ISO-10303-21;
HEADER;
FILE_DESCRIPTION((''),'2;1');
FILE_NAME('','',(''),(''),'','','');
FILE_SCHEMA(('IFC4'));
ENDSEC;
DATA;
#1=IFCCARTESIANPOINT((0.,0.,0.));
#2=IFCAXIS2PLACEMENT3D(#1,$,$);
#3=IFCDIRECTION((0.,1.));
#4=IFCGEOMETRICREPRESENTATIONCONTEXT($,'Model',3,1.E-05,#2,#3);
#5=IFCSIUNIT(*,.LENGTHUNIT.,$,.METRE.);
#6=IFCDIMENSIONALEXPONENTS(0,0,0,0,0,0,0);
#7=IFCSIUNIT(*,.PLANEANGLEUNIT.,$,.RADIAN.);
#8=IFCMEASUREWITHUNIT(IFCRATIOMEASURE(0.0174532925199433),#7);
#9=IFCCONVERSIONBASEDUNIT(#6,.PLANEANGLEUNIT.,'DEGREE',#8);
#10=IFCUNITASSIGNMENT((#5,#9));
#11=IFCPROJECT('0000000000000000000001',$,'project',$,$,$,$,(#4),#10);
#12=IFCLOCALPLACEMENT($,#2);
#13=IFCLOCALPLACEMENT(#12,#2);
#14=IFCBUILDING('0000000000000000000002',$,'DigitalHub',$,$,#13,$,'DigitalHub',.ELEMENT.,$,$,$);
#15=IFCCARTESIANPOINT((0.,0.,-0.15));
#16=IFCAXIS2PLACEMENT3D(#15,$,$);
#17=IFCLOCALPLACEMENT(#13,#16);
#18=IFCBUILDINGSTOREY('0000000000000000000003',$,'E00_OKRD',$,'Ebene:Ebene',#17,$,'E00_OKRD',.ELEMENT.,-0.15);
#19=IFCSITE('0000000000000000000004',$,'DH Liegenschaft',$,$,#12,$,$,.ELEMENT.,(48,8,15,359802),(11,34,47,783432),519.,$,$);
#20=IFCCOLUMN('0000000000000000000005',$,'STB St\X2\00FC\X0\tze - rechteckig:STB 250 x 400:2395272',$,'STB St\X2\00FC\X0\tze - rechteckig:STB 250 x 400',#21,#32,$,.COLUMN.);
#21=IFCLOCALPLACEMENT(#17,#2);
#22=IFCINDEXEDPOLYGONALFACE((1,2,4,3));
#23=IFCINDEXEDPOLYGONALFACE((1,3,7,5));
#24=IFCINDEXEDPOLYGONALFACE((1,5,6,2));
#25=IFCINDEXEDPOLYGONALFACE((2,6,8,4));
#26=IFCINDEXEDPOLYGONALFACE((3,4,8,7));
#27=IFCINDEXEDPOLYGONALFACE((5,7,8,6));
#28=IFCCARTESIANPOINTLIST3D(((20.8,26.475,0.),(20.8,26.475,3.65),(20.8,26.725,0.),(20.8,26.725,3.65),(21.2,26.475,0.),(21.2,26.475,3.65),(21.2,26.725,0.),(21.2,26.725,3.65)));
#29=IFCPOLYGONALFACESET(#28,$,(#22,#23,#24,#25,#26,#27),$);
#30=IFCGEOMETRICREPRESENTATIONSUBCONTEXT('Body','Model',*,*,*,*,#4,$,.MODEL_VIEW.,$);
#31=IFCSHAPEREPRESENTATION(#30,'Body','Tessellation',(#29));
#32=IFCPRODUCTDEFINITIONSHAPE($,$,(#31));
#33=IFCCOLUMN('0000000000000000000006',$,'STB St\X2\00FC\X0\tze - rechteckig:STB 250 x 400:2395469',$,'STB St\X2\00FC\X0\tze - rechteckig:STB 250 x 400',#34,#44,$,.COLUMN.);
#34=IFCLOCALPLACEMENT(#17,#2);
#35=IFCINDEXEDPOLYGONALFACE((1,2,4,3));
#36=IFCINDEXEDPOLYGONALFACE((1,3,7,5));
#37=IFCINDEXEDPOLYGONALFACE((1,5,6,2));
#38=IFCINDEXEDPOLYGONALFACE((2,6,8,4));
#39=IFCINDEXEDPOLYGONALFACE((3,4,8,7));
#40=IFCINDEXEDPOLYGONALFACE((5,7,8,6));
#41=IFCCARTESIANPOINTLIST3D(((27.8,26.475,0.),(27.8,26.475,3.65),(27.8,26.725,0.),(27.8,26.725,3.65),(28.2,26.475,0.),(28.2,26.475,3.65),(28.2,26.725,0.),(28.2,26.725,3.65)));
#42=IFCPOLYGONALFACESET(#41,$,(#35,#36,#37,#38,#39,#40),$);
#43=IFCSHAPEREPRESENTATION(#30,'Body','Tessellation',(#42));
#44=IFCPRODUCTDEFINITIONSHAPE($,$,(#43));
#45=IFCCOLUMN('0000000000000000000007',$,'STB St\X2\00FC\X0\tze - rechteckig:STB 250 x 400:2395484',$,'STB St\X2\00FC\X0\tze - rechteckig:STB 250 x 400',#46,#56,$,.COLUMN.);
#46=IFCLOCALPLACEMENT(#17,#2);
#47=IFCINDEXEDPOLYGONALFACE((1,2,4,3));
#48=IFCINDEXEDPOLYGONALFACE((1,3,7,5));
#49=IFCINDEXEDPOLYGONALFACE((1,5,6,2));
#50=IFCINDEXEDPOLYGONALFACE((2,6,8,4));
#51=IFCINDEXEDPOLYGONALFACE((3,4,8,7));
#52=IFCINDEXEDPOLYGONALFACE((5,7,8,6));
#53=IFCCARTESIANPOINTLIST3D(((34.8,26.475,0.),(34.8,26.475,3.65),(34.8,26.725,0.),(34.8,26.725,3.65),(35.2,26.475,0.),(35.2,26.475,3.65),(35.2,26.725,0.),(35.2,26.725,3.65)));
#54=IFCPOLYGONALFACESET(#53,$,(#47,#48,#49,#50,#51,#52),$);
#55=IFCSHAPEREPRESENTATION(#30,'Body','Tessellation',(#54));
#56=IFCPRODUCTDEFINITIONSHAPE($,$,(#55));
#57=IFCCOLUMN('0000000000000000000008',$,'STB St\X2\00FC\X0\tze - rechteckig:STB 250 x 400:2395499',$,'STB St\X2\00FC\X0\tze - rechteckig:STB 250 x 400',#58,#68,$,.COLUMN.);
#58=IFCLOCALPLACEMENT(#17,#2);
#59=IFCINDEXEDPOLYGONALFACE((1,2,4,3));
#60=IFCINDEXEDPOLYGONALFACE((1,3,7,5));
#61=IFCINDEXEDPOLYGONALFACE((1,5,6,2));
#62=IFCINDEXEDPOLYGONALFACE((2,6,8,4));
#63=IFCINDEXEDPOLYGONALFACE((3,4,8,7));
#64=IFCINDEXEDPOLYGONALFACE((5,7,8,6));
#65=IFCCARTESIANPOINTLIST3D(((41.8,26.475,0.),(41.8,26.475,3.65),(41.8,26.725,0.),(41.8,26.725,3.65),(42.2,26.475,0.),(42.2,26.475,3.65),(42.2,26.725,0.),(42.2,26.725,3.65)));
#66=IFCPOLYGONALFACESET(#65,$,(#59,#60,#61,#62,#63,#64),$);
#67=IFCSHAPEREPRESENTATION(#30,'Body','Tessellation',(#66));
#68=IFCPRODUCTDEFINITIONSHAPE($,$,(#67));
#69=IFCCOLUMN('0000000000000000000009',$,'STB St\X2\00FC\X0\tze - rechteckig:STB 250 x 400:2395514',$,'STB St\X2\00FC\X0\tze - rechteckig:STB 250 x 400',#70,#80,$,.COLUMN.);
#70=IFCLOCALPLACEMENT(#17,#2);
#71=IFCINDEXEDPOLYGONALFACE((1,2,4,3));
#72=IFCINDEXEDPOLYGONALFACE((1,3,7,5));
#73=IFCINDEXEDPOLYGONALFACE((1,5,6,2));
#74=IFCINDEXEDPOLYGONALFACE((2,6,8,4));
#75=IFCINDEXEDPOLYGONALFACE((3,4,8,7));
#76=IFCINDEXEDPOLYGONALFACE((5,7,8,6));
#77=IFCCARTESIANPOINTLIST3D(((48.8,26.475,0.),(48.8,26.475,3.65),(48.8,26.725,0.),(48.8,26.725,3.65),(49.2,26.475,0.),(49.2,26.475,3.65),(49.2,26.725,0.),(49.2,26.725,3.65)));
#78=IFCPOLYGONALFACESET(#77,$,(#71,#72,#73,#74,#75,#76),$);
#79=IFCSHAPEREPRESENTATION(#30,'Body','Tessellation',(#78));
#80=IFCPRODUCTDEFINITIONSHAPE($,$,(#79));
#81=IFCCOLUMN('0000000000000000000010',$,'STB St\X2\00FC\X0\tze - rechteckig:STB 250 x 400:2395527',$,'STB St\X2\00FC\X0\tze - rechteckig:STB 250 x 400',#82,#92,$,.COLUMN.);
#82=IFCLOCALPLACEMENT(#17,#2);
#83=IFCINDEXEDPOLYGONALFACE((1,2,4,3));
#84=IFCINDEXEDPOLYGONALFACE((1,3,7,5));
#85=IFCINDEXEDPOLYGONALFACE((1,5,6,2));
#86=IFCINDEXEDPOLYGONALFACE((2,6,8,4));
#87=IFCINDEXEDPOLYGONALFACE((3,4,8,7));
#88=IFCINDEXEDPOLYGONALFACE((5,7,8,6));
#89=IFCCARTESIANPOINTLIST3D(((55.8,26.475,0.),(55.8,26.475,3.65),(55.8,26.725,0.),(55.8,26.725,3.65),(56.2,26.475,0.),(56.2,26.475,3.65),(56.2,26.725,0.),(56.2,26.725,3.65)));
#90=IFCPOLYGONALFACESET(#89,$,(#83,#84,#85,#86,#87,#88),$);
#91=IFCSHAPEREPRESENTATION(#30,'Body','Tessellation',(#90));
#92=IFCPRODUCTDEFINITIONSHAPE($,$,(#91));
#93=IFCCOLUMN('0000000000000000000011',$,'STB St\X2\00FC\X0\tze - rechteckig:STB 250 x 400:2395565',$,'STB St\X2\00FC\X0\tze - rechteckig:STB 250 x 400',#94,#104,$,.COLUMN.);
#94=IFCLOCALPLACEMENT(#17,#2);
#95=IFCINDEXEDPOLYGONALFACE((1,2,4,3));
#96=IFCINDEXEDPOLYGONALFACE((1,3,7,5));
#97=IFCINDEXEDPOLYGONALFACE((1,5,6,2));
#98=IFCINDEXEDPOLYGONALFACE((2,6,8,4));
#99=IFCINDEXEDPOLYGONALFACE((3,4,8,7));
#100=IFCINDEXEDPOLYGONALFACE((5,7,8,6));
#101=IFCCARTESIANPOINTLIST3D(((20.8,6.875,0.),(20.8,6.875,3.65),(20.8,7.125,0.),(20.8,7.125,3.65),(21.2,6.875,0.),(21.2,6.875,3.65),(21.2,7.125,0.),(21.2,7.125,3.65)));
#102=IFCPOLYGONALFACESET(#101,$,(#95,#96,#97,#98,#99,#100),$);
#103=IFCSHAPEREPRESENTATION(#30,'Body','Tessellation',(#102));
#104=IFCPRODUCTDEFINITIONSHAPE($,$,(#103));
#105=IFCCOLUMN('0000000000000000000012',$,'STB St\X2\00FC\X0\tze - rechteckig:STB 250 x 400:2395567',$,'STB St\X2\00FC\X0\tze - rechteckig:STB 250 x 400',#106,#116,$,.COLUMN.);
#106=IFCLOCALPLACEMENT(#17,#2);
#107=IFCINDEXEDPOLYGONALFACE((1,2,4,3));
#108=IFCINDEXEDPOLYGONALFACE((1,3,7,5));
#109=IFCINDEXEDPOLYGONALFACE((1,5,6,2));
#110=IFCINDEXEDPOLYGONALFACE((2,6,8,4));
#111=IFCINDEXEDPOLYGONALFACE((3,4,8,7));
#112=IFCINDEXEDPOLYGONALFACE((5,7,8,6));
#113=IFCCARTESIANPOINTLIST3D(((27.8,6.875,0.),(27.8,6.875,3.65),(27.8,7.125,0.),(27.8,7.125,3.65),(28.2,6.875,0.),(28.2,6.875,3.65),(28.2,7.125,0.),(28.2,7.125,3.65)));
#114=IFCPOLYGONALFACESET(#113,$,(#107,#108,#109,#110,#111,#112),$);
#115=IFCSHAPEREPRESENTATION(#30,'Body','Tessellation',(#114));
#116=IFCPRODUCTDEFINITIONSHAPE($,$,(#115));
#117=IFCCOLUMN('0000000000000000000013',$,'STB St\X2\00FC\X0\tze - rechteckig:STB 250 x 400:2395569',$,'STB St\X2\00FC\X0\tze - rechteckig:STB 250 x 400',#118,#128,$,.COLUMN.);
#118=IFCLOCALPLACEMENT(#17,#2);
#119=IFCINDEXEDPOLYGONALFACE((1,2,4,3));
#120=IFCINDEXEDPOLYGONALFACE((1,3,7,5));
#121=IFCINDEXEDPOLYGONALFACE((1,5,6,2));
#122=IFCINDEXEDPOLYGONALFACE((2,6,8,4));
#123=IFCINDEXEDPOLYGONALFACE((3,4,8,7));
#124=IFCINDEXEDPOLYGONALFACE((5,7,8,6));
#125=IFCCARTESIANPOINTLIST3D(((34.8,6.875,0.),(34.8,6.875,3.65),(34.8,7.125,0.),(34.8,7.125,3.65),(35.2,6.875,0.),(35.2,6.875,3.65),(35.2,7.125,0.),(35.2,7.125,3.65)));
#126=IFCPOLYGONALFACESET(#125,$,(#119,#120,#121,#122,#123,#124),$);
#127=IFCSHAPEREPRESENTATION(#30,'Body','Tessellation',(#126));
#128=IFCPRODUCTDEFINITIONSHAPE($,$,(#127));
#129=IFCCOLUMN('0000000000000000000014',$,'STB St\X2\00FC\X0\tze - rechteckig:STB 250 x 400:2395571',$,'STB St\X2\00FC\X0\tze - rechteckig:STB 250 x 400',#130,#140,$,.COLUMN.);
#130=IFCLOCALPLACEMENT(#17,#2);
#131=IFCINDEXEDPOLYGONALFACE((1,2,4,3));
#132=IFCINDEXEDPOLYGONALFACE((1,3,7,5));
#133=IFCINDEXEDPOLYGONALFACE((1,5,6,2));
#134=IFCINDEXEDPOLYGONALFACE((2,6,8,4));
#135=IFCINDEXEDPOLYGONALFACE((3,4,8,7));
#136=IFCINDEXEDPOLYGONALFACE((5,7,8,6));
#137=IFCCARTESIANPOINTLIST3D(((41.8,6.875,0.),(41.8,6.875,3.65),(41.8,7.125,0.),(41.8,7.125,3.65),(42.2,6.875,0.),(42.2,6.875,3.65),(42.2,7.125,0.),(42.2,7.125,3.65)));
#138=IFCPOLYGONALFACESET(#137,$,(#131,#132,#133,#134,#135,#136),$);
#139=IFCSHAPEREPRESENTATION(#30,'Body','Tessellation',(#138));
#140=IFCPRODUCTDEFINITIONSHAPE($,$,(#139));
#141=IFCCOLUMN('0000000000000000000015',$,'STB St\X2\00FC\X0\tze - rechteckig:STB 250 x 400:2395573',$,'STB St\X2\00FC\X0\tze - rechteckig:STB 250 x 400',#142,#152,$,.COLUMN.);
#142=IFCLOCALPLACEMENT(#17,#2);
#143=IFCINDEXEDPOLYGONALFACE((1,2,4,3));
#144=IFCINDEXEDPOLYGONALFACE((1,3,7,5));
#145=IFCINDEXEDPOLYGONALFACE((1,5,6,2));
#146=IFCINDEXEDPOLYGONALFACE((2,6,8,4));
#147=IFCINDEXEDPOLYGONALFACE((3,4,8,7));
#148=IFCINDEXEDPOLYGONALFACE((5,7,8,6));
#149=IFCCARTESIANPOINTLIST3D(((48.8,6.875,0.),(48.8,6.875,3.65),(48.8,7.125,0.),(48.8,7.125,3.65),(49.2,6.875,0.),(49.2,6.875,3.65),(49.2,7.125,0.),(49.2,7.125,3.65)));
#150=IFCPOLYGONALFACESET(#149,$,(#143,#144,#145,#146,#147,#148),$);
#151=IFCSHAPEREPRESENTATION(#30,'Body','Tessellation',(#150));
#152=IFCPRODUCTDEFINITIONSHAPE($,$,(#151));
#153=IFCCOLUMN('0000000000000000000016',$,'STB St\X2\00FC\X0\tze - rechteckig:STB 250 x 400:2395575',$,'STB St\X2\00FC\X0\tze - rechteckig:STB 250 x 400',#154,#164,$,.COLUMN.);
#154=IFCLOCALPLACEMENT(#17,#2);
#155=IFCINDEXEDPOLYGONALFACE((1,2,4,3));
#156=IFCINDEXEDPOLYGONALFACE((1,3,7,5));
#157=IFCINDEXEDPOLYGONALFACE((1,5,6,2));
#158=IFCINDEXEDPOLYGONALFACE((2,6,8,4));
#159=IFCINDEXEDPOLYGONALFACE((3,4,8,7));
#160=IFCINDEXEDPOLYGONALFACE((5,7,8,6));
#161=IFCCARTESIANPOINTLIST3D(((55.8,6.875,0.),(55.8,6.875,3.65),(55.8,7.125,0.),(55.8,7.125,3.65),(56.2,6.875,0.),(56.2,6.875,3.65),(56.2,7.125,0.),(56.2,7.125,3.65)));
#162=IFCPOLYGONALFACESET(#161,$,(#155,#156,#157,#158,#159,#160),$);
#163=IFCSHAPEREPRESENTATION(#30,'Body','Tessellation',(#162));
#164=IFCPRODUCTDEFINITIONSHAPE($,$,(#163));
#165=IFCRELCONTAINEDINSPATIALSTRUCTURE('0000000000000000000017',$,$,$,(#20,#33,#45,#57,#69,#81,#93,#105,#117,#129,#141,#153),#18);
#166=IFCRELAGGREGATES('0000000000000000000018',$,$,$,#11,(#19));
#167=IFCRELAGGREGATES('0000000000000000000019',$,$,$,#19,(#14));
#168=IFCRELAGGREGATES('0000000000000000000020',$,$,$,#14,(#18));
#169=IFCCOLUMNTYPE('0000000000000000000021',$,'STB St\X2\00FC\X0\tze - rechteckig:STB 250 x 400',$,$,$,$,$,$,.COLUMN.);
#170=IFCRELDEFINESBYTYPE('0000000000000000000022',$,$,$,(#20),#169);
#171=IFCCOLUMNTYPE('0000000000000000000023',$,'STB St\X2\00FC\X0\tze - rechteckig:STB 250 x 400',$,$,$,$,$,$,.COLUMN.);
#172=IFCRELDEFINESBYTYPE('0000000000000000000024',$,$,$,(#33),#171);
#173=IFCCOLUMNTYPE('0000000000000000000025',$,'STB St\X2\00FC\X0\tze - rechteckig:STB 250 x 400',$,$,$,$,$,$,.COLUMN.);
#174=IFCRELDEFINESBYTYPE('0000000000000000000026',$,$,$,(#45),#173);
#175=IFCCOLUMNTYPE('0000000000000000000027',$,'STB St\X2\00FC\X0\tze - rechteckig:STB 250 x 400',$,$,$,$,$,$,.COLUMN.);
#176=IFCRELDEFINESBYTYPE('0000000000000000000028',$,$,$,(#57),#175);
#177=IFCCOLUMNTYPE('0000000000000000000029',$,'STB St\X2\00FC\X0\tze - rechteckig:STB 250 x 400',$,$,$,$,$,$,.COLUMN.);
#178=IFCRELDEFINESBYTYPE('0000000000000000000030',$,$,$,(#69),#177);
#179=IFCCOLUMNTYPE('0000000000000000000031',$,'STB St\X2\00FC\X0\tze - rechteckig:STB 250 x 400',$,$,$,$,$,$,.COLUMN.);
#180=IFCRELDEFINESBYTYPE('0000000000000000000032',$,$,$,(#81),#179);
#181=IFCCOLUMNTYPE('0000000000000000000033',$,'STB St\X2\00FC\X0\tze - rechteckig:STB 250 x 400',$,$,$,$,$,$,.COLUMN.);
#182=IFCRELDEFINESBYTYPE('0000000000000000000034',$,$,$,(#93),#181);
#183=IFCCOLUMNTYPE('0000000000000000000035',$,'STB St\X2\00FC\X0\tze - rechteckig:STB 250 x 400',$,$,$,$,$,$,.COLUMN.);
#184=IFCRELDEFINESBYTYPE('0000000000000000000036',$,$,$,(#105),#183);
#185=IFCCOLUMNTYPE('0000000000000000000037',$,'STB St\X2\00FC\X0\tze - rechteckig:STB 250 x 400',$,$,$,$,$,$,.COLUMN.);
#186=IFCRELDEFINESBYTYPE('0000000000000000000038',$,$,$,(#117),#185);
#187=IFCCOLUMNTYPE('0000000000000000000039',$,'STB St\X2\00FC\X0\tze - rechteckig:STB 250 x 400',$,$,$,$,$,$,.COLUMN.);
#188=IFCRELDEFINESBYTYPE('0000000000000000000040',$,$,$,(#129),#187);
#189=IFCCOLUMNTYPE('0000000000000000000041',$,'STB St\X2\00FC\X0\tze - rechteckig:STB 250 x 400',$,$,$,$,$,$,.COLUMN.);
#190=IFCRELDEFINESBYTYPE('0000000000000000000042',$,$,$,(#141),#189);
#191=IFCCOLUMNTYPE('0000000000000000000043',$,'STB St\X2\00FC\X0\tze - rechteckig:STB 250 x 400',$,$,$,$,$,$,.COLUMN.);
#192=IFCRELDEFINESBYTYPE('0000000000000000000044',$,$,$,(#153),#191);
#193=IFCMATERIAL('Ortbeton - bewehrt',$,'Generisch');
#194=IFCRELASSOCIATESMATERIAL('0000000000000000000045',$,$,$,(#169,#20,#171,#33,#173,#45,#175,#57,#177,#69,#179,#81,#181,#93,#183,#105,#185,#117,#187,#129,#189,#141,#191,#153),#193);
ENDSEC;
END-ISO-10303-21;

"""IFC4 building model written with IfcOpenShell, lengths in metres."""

from ifc_helpers import new_model, entity, si_unit, converted_unit, direction, frame, origin, place, context, subcontext, project, spatial, indexed_curve, outline, extrude, source, transform, mapped, material, type_object, type_shapes, element, save


model = new_model("IFC4")

# Units and contexts
model_context = context("Model", 3, precision=1e-05, world=origin(), true_north=direction((0.0, 1.0)))
body_context = subcontext(model_context, "Body", "Model", "MODEL_VIEW")
ifc_project = project(units=[si_unit("LENGTHUNIT", "METRE"), converted_unit("PLANEANGLEUNIT", "DEGREE", entity("IfcRatioMeasure", 0.0174532925199433), si_unit("PLANEANGLEUNIT", "RADIAN"), dimensions=[0, 0, 0, 0, 0, 0, 0])], contexts=[model_context])

# Site, building, storey
site_placement = place(None, frame((0.0, 0.0, 0.0)))
site = spatial("IfcSite", under=ifc_project, at=site_placement, Name="DH Liegenschaft", CompositionType="ELEMENT", RefLatitude=(48, 8, 15, 359802), RefLongitude=(11, 34, 47, 783432), RefElevation=519.0)
building_placement = place(site_placement, origin())
building = spatial("IfcBuilding", under=site, at=building_placement, Name="DigitalHub", LongName="DigitalHub", CompositionType="ELEMENT")
storey_placement = place(building_placement, frame((0.0, 0.0, -0.15)))
storey = spatial("IfcBuildingStorey", under=building, at=storey_placement, Name="E00_OKRD", ObjectType="Ebene:Ebene", LongName="E00_OKRD", CompositionType="ELEMENT", Elevation=-0.15)

# Columns
ifc_material_1 = material(Name="Ortbeton - bewehrt", Category="Generisch")
column_type_1 = type_object("IfcColumnType", Name="STB Stütze - rechteckig:STB 250 x 400", PredefinedType="COLUMN", material=ifc_material_1)
shared_shape_1 = source(origin(), body_context, "Body", "SweptSolid", [
    extrude(outline(indexed_curve([(-0.125, -0.2), (0.125, -0.2), (0.125, 0.2), (-0.125, 0.2), (-0.125, -0.2)], self_intersect=False)), frame((21.0, 26.6, -0.15), z_axis=(0.0, 0.0, 1.0), x_axis=(0.0, -1.0, 0.0)), (0.0, 0.0, 1.0), 3.65),
])
type_shapes(column_type_1, [shared_shape_1])
column_1_placement = place(storey_placement, frame((0.0, 0.0, 0.15)))
element("IfcColumn", 1, at=column_1_placement, inside=storey, type_object=column_type_1, material=ifc_material_1, Name="STB Stütze - rechteckig:STB 250 x 400:2395272", ObjectType="STB Stütze - rechteckig:STB 250 x 400", PredefinedType="COLUMN", context=body_context, shape_type="MappedRepresentation", body=[
    mapped(shared_shape_1, transform((0.0, 0.0, 0.0), scale=1.0)),
])
column_type_2 = type_object("IfcColumnType", Name="STB Stütze - rechteckig:STB 250 x 400", PredefinedType="COLUMN", material=ifc_material_1)
shared_shape_2 = source(origin(), body_context, "Body", "SweptSolid", [
    extrude(outline(indexed_curve([(-0.125, -0.2), (0.125, -0.2), (0.125, 0.2), (-0.125, 0.2), (-0.125, -0.2)], self_intersect=False)), frame((28.0, 26.6, -0.15), z_axis=(0.0, 0.0, 1.0), x_axis=(0.0, -1.0, 0.0)), (0.0, 0.0, 1.0), 3.65),
])
type_shapes(column_type_2, [shared_shape_2])
column_2_placement = place(storey_placement, frame((0.0, 0.0, 0.15)))
element("IfcColumn", 2, at=column_2_placement, inside=storey, type_object=column_type_2, material=ifc_material_1, Name="STB Stütze - rechteckig:STB 250 x 400:2395469", ObjectType="STB Stütze - rechteckig:STB 250 x 400", PredefinedType="COLUMN", context=body_context, shape_type="MappedRepresentation", body=[
    mapped(shared_shape_2, transform((0.0, 0.0, 0.0), scale=1.0)),
])
column_type_3 = type_object("IfcColumnType", Name="STB Stütze - rechteckig:STB 250 x 400", PredefinedType="COLUMN", material=ifc_material_1)
shared_shape_3 = source(origin(), body_context, "Body", "SweptSolid", [
    extrude(outline(indexed_curve([(-0.125, -0.2), (0.125, -0.2), (0.125, 0.2), (-0.125, 0.2), (-0.125, -0.2)], self_intersect=False)), frame((35.0, 26.6, -0.15), z_axis=(0.0, 0.0, 1.0), x_axis=(0.0, -1.0, 0.0)), (0.0, 0.0, 1.0), 3.65),
])
type_shapes(column_type_3, [shared_shape_3])
column_3_placement = place(storey_placement, frame((0.0, 0.0, 0.15)))
element("IfcColumn", 3, at=column_3_placement, inside=storey, type_object=column_type_3, material=ifc_material_1, Name="STB Stütze - rechteckig:STB 250 x 400:2395484", ObjectType="STB Stütze - rechteckig:STB 250 x 400", PredefinedType="COLUMN", context=body_context, shape_type="MappedRepresentation", body=[
    mapped(shared_shape_3, transform((0.0, 0.0, 0.0), scale=1.0)),
])
column_type_4 = type_object("IfcColumnType", Name="STB Stütze - rechteckig:STB 250 x 400", PredefinedType="COLUMN", material=ifc_material_1)
shared_shape_4 = source(origin(), body_context, "Body", "SweptSolid", [
    extrude(outline(indexed_curve([(-0.125, -0.2), (0.125, -0.2), (0.125, 0.2), (-0.125, 0.2), (-0.125, -0.2)], self_intersect=False)), frame((42.0, 26.6, -0.15), z_axis=(0.0, 0.0, 1.0), x_axis=(0.0, -1.0, 0.0)), (0.0, 0.0, 1.0), 3.65),
])
type_shapes(column_type_4, [shared_shape_4])
column_4_placement = place(storey_placement, frame((0.0, 0.0, 0.15)))
element("IfcColumn", 4, at=column_4_placement, inside=storey, type_object=column_type_4, material=ifc_material_1, Name="STB Stütze - rechteckig:STB 250 x 400:2395499", ObjectType="STB Stütze - rechteckig:STB 250 x 400", PredefinedType="COLUMN", context=body_context, shape_type="MappedRepresentation", body=[
    mapped(shared_shape_4, transform((0.0, 0.0, 0.0), scale=1.0)),
])
column_type_5 = type_object("IfcColumnType", Name="STB Stütze - rechteckig:STB 250 x 400", PredefinedType="COLUMN", material=ifc_material_1)
shared_shape_5 = source(origin(), body_context, "Body", "SweptSolid", [
    extrude(outline(indexed_curve([(-0.125, -0.2), (0.125, -0.2), (0.125, 0.2), (-0.125, 0.2), (-0.125, -0.2)], self_intersect=False)), frame((49.0, 26.6, -0.15), z_axis=(0.0, 0.0, 1.0), x_axis=(0.0, -1.0, 0.0)), (0.0, 0.0, 1.0), 3.65),
])
type_shapes(column_type_5, [shared_shape_5])
column_5_placement = place(storey_placement, frame((0.0, 0.0, 0.15)))
element("IfcColumn", 5, at=column_5_placement, inside=storey, type_object=column_type_5, material=ifc_material_1, Name="STB Stütze - rechteckig:STB 250 x 400:2395514", ObjectType="STB Stütze - rechteckig:STB 250 x 400", PredefinedType="COLUMN", context=body_context, shape_type="MappedRepresentation", body=[
    mapped(shared_shape_5, transform((0.0, 0.0, 0.0), scale=1.0)),
])
column_type_6 = type_object("IfcColumnType", Name="STB Stütze - rechteckig:STB 250 x 400", PredefinedType="COLUMN", material=ifc_material_1)
shared_shape_6 = source(origin(), body_context, "Body", "SweptSolid", [
    extrude(outline(indexed_curve([(-0.125, -0.2), (0.125, -0.2), (0.125, 0.2), (-0.125, 0.2), (-0.125, -0.2)], self_intersect=False)), frame((56.0, 26.6, -0.15), z_axis=(0.0, 0.0, 1.0), x_axis=(0.0, -1.0, 0.0)), (0.0, 0.0, 1.0), 3.65),
])
type_shapes(column_type_6, [shared_shape_6])
column_6_placement = place(storey_placement, frame((0.0, 0.0, 0.15)))
element("IfcColumn", 6, at=column_6_placement, inside=storey, type_object=column_type_6, material=ifc_material_1, Name="STB Stütze - rechteckig:STB 250 x 400:2395527", ObjectType="STB Stütze - rechteckig:STB 250 x 400", PredefinedType="COLUMN", context=body_context, shape_type="MappedRepresentation", body=[
    mapped(shared_shape_6, transform((0.0, 0.0, 0.0), scale=1.0)),
])
column_type_7 = type_object("IfcColumnType", Name="STB Stütze - rechteckig:STB 250 x 400", PredefinedType="COLUMN", material=ifc_material_1)
shared_shape_7 = source(origin(), body_context, "Body", "SweptSolid", [
    extrude(outline(indexed_curve([(-0.125, -0.2), (0.125, -0.2), (0.125, 0.2), (-0.125, 0.2), (-0.125, -0.2)], self_intersect=False)), frame((21.0, 7.0, -0.15), z_axis=(0.0, 0.0, 1.0), x_axis=(0.0, -1.0, 0.0)), (0.0, 0.0, 1.0), 3.65),
])
type_shapes(column_type_7, [shared_shape_7])
column_7_placement = place(storey_placement, frame((0.0, 0.0, 0.15)))
element("IfcColumn", 7, at=column_7_placement, inside=storey, type_object=column_type_7, material=ifc_material_1, Name="STB Stütze - rechteckig:STB 250 x 400:2395565", ObjectType="STB Stütze - rechteckig:STB 250 x 400", PredefinedType="COLUMN", context=body_context, shape_type="MappedRepresentation", body=[
    mapped(shared_shape_7, transform((0.0, 0.0, 0.0), scale=1.0)),
])
column_type_8 = type_object("IfcColumnType", Name="STB Stütze - rechteckig:STB 250 x 400", PredefinedType="COLUMN", material=ifc_material_1)
shared_shape_8 = source(origin(), body_context, "Body", "SweptSolid", [
    extrude(outline(indexed_curve([(-0.125, -0.2), (0.125, -0.2), (0.125, 0.2), (-0.125, 0.2), (-0.125, -0.2)], self_intersect=False)), frame((28.0, 7.0, -0.15), z_axis=(0.0, 0.0, 1.0), x_axis=(0.0, -1.0, 0.0)), (0.0, 0.0, 1.0), 3.65),
])
type_shapes(column_type_8, [shared_shape_8])
column_8_placement = place(storey_placement, frame((0.0, 0.0, 0.15)))
element("IfcColumn", 8, at=column_8_placement, inside=storey, type_object=column_type_8, material=ifc_material_1, Name="STB Stütze - rechteckig:STB 250 x 400:2395567", ObjectType="STB Stütze - rechteckig:STB 250 x 400", PredefinedType="COLUMN", context=body_context, shape_type="MappedRepresentation", body=[
    mapped(shared_shape_8, transform((0.0, 0.0, 0.0), scale=1.0)),
])
column_type_9 = type_object("IfcColumnType", Name="STB Stütze - rechteckig:STB 250 x 400", PredefinedType="COLUMN", material=ifc_material_1)
shared_shape_9 = source(origin(), body_context, "Body", "SweptSolid", [
    extrude(outline(indexed_curve([(-0.125, -0.2), (0.125, -0.2), (0.125, 0.2), (-0.125, 0.2), (-0.125, -0.2)], self_intersect=False)), frame((35.0, 7.0, -0.15), z_axis=(0.0, 0.0, 1.0), x_axis=(0.0, -1.0, 0.0)), (0.0, 0.0, 1.0), 3.65),
])
type_shapes(column_type_9, [shared_shape_9])
column_9_placement = place(storey_placement, frame((0.0, 0.0, 0.15)))
element("IfcColumn", 9, at=column_9_placement, inside=storey, type_object=column_type_9, material=ifc_material_1, Name="STB Stütze - rechteckig:STB 250 x 400:2395569", ObjectType="STB Stütze - rechteckig:STB 250 x 400", PredefinedType="COLUMN", context=body_context, shape_type="MappedRepresentation", body=[
    mapped(shared_shape_9, transform((0.0, 0.0, 0.0), scale=1.0)),
])
column_type_10 = type_object("IfcColumnType", Name="STB Stütze - rechteckig:STB 250 x 400", PredefinedType="COLUMN", material=ifc_material_1)
shared_shape_10 = source(origin(), body_context, "Body", "SweptSolid", [
    extrude(outline(indexed_curve([(-0.125, -0.2), (0.125, -0.2), (0.125, 0.2), (-0.125, 0.2), (-0.125, -0.2)], self_intersect=False)), frame((42.0, 7.0, -0.15), z_axis=(0.0, 0.0, 1.0), x_axis=(0.0, -1.0, 0.0)), (0.0, 0.0, 1.0), 3.65),
])
type_shapes(column_type_10, [shared_shape_10])
column_10_placement = place(storey_placement, frame((0.0, 0.0, 0.15)))
element("IfcColumn", 10, at=column_10_placement, inside=storey, type_object=column_type_10, material=ifc_material_1, Name="STB Stütze - rechteckig:STB 250 x 400:2395571", ObjectType="STB Stütze - rechteckig:STB 250 x 400", PredefinedType="COLUMN", context=body_context, shape_type="MappedRepresentation", body=[
    mapped(shared_shape_10, transform((0.0, 0.0, 0.0), scale=1.0)),
])
column_type_11 = type_object("IfcColumnType", Name="STB Stütze - rechteckig:STB 250 x 400", PredefinedType="COLUMN", material=ifc_material_1)
shared_shape_11 = source(origin(), body_context, "Body", "SweptSolid", [
    extrude(outline(indexed_curve([(-0.125, -0.2), (0.125, -0.2), (0.125, 0.2), (-0.125, 0.2), (-0.125, -0.2)], self_intersect=False)), frame((49.0, 7.0, -0.15), z_axis=(0.0, 0.0, 1.0), x_axis=(0.0, -1.0, 0.0)), (0.0, 0.0, 1.0), 3.65),
])
type_shapes(column_type_11, [shared_shape_11])
column_11_placement = place(storey_placement, frame((0.0, 0.0, 0.15)))
element("IfcColumn", 11, at=column_11_placement, inside=storey, type_object=column_type_11, material=ifc_material_1, Name="STB Stütze - rechteckig:STB 250 x 400:2395573", ObjectType="STB Stütze - rechteckig:STB 250 x 400", PredefinedType="COLUMN", context=body_context, shape_type="MappedRepresentation", body=[
    mapped(shared_shape_11, transform((0.0, 0.0, 0.0), scale=1.0)),
])
column_type_12 = type_object("IfcColumnType", Name="STB Stütze - rechteckig:STB 250 x 400", PredefinedType="COLUMN", material=ifc_material_1)
shared_shape_12 = source(origin(), body_context, "Body", "SweptSolid", [
    extrude(outline(indexed_curve([(-0.125, -0.2), (0.125, -0.2), (0.125, 0.2), (-0.125, 0.2), (-0.125, -0.2)], self_intersect=False)), frame((56.0, 7.0, -0.15), z_axis=(0.0, 0.0, 1.0), x_axis=(0.0, -1.0, 0.0)), (0.0, 0.0, 1.0), 3.65),
])
type_shapes(column_type_12, [shared_shape_12])
column_12_placement = place(storey_placement, frame((0.0, 0.0, 0.15)))
element("IfcColumn", 12, at=column_12_placement, inside=storey, type_object=column_type_12, material=ifc_material_1, Name="STB Stütze - rechteckig:STB 250 x 400:2395575", ObjectType="STB Stütze - rechteckig:STB 250 x 400", PredefinedType="COLUMN", context=body_context, shape_type="MappedRepresentation", body=[
    mapped(shared_shape_12, transform((0.0, 0.0, 0.0), scale=1.0)),
])

save(model, "model.ifc")
